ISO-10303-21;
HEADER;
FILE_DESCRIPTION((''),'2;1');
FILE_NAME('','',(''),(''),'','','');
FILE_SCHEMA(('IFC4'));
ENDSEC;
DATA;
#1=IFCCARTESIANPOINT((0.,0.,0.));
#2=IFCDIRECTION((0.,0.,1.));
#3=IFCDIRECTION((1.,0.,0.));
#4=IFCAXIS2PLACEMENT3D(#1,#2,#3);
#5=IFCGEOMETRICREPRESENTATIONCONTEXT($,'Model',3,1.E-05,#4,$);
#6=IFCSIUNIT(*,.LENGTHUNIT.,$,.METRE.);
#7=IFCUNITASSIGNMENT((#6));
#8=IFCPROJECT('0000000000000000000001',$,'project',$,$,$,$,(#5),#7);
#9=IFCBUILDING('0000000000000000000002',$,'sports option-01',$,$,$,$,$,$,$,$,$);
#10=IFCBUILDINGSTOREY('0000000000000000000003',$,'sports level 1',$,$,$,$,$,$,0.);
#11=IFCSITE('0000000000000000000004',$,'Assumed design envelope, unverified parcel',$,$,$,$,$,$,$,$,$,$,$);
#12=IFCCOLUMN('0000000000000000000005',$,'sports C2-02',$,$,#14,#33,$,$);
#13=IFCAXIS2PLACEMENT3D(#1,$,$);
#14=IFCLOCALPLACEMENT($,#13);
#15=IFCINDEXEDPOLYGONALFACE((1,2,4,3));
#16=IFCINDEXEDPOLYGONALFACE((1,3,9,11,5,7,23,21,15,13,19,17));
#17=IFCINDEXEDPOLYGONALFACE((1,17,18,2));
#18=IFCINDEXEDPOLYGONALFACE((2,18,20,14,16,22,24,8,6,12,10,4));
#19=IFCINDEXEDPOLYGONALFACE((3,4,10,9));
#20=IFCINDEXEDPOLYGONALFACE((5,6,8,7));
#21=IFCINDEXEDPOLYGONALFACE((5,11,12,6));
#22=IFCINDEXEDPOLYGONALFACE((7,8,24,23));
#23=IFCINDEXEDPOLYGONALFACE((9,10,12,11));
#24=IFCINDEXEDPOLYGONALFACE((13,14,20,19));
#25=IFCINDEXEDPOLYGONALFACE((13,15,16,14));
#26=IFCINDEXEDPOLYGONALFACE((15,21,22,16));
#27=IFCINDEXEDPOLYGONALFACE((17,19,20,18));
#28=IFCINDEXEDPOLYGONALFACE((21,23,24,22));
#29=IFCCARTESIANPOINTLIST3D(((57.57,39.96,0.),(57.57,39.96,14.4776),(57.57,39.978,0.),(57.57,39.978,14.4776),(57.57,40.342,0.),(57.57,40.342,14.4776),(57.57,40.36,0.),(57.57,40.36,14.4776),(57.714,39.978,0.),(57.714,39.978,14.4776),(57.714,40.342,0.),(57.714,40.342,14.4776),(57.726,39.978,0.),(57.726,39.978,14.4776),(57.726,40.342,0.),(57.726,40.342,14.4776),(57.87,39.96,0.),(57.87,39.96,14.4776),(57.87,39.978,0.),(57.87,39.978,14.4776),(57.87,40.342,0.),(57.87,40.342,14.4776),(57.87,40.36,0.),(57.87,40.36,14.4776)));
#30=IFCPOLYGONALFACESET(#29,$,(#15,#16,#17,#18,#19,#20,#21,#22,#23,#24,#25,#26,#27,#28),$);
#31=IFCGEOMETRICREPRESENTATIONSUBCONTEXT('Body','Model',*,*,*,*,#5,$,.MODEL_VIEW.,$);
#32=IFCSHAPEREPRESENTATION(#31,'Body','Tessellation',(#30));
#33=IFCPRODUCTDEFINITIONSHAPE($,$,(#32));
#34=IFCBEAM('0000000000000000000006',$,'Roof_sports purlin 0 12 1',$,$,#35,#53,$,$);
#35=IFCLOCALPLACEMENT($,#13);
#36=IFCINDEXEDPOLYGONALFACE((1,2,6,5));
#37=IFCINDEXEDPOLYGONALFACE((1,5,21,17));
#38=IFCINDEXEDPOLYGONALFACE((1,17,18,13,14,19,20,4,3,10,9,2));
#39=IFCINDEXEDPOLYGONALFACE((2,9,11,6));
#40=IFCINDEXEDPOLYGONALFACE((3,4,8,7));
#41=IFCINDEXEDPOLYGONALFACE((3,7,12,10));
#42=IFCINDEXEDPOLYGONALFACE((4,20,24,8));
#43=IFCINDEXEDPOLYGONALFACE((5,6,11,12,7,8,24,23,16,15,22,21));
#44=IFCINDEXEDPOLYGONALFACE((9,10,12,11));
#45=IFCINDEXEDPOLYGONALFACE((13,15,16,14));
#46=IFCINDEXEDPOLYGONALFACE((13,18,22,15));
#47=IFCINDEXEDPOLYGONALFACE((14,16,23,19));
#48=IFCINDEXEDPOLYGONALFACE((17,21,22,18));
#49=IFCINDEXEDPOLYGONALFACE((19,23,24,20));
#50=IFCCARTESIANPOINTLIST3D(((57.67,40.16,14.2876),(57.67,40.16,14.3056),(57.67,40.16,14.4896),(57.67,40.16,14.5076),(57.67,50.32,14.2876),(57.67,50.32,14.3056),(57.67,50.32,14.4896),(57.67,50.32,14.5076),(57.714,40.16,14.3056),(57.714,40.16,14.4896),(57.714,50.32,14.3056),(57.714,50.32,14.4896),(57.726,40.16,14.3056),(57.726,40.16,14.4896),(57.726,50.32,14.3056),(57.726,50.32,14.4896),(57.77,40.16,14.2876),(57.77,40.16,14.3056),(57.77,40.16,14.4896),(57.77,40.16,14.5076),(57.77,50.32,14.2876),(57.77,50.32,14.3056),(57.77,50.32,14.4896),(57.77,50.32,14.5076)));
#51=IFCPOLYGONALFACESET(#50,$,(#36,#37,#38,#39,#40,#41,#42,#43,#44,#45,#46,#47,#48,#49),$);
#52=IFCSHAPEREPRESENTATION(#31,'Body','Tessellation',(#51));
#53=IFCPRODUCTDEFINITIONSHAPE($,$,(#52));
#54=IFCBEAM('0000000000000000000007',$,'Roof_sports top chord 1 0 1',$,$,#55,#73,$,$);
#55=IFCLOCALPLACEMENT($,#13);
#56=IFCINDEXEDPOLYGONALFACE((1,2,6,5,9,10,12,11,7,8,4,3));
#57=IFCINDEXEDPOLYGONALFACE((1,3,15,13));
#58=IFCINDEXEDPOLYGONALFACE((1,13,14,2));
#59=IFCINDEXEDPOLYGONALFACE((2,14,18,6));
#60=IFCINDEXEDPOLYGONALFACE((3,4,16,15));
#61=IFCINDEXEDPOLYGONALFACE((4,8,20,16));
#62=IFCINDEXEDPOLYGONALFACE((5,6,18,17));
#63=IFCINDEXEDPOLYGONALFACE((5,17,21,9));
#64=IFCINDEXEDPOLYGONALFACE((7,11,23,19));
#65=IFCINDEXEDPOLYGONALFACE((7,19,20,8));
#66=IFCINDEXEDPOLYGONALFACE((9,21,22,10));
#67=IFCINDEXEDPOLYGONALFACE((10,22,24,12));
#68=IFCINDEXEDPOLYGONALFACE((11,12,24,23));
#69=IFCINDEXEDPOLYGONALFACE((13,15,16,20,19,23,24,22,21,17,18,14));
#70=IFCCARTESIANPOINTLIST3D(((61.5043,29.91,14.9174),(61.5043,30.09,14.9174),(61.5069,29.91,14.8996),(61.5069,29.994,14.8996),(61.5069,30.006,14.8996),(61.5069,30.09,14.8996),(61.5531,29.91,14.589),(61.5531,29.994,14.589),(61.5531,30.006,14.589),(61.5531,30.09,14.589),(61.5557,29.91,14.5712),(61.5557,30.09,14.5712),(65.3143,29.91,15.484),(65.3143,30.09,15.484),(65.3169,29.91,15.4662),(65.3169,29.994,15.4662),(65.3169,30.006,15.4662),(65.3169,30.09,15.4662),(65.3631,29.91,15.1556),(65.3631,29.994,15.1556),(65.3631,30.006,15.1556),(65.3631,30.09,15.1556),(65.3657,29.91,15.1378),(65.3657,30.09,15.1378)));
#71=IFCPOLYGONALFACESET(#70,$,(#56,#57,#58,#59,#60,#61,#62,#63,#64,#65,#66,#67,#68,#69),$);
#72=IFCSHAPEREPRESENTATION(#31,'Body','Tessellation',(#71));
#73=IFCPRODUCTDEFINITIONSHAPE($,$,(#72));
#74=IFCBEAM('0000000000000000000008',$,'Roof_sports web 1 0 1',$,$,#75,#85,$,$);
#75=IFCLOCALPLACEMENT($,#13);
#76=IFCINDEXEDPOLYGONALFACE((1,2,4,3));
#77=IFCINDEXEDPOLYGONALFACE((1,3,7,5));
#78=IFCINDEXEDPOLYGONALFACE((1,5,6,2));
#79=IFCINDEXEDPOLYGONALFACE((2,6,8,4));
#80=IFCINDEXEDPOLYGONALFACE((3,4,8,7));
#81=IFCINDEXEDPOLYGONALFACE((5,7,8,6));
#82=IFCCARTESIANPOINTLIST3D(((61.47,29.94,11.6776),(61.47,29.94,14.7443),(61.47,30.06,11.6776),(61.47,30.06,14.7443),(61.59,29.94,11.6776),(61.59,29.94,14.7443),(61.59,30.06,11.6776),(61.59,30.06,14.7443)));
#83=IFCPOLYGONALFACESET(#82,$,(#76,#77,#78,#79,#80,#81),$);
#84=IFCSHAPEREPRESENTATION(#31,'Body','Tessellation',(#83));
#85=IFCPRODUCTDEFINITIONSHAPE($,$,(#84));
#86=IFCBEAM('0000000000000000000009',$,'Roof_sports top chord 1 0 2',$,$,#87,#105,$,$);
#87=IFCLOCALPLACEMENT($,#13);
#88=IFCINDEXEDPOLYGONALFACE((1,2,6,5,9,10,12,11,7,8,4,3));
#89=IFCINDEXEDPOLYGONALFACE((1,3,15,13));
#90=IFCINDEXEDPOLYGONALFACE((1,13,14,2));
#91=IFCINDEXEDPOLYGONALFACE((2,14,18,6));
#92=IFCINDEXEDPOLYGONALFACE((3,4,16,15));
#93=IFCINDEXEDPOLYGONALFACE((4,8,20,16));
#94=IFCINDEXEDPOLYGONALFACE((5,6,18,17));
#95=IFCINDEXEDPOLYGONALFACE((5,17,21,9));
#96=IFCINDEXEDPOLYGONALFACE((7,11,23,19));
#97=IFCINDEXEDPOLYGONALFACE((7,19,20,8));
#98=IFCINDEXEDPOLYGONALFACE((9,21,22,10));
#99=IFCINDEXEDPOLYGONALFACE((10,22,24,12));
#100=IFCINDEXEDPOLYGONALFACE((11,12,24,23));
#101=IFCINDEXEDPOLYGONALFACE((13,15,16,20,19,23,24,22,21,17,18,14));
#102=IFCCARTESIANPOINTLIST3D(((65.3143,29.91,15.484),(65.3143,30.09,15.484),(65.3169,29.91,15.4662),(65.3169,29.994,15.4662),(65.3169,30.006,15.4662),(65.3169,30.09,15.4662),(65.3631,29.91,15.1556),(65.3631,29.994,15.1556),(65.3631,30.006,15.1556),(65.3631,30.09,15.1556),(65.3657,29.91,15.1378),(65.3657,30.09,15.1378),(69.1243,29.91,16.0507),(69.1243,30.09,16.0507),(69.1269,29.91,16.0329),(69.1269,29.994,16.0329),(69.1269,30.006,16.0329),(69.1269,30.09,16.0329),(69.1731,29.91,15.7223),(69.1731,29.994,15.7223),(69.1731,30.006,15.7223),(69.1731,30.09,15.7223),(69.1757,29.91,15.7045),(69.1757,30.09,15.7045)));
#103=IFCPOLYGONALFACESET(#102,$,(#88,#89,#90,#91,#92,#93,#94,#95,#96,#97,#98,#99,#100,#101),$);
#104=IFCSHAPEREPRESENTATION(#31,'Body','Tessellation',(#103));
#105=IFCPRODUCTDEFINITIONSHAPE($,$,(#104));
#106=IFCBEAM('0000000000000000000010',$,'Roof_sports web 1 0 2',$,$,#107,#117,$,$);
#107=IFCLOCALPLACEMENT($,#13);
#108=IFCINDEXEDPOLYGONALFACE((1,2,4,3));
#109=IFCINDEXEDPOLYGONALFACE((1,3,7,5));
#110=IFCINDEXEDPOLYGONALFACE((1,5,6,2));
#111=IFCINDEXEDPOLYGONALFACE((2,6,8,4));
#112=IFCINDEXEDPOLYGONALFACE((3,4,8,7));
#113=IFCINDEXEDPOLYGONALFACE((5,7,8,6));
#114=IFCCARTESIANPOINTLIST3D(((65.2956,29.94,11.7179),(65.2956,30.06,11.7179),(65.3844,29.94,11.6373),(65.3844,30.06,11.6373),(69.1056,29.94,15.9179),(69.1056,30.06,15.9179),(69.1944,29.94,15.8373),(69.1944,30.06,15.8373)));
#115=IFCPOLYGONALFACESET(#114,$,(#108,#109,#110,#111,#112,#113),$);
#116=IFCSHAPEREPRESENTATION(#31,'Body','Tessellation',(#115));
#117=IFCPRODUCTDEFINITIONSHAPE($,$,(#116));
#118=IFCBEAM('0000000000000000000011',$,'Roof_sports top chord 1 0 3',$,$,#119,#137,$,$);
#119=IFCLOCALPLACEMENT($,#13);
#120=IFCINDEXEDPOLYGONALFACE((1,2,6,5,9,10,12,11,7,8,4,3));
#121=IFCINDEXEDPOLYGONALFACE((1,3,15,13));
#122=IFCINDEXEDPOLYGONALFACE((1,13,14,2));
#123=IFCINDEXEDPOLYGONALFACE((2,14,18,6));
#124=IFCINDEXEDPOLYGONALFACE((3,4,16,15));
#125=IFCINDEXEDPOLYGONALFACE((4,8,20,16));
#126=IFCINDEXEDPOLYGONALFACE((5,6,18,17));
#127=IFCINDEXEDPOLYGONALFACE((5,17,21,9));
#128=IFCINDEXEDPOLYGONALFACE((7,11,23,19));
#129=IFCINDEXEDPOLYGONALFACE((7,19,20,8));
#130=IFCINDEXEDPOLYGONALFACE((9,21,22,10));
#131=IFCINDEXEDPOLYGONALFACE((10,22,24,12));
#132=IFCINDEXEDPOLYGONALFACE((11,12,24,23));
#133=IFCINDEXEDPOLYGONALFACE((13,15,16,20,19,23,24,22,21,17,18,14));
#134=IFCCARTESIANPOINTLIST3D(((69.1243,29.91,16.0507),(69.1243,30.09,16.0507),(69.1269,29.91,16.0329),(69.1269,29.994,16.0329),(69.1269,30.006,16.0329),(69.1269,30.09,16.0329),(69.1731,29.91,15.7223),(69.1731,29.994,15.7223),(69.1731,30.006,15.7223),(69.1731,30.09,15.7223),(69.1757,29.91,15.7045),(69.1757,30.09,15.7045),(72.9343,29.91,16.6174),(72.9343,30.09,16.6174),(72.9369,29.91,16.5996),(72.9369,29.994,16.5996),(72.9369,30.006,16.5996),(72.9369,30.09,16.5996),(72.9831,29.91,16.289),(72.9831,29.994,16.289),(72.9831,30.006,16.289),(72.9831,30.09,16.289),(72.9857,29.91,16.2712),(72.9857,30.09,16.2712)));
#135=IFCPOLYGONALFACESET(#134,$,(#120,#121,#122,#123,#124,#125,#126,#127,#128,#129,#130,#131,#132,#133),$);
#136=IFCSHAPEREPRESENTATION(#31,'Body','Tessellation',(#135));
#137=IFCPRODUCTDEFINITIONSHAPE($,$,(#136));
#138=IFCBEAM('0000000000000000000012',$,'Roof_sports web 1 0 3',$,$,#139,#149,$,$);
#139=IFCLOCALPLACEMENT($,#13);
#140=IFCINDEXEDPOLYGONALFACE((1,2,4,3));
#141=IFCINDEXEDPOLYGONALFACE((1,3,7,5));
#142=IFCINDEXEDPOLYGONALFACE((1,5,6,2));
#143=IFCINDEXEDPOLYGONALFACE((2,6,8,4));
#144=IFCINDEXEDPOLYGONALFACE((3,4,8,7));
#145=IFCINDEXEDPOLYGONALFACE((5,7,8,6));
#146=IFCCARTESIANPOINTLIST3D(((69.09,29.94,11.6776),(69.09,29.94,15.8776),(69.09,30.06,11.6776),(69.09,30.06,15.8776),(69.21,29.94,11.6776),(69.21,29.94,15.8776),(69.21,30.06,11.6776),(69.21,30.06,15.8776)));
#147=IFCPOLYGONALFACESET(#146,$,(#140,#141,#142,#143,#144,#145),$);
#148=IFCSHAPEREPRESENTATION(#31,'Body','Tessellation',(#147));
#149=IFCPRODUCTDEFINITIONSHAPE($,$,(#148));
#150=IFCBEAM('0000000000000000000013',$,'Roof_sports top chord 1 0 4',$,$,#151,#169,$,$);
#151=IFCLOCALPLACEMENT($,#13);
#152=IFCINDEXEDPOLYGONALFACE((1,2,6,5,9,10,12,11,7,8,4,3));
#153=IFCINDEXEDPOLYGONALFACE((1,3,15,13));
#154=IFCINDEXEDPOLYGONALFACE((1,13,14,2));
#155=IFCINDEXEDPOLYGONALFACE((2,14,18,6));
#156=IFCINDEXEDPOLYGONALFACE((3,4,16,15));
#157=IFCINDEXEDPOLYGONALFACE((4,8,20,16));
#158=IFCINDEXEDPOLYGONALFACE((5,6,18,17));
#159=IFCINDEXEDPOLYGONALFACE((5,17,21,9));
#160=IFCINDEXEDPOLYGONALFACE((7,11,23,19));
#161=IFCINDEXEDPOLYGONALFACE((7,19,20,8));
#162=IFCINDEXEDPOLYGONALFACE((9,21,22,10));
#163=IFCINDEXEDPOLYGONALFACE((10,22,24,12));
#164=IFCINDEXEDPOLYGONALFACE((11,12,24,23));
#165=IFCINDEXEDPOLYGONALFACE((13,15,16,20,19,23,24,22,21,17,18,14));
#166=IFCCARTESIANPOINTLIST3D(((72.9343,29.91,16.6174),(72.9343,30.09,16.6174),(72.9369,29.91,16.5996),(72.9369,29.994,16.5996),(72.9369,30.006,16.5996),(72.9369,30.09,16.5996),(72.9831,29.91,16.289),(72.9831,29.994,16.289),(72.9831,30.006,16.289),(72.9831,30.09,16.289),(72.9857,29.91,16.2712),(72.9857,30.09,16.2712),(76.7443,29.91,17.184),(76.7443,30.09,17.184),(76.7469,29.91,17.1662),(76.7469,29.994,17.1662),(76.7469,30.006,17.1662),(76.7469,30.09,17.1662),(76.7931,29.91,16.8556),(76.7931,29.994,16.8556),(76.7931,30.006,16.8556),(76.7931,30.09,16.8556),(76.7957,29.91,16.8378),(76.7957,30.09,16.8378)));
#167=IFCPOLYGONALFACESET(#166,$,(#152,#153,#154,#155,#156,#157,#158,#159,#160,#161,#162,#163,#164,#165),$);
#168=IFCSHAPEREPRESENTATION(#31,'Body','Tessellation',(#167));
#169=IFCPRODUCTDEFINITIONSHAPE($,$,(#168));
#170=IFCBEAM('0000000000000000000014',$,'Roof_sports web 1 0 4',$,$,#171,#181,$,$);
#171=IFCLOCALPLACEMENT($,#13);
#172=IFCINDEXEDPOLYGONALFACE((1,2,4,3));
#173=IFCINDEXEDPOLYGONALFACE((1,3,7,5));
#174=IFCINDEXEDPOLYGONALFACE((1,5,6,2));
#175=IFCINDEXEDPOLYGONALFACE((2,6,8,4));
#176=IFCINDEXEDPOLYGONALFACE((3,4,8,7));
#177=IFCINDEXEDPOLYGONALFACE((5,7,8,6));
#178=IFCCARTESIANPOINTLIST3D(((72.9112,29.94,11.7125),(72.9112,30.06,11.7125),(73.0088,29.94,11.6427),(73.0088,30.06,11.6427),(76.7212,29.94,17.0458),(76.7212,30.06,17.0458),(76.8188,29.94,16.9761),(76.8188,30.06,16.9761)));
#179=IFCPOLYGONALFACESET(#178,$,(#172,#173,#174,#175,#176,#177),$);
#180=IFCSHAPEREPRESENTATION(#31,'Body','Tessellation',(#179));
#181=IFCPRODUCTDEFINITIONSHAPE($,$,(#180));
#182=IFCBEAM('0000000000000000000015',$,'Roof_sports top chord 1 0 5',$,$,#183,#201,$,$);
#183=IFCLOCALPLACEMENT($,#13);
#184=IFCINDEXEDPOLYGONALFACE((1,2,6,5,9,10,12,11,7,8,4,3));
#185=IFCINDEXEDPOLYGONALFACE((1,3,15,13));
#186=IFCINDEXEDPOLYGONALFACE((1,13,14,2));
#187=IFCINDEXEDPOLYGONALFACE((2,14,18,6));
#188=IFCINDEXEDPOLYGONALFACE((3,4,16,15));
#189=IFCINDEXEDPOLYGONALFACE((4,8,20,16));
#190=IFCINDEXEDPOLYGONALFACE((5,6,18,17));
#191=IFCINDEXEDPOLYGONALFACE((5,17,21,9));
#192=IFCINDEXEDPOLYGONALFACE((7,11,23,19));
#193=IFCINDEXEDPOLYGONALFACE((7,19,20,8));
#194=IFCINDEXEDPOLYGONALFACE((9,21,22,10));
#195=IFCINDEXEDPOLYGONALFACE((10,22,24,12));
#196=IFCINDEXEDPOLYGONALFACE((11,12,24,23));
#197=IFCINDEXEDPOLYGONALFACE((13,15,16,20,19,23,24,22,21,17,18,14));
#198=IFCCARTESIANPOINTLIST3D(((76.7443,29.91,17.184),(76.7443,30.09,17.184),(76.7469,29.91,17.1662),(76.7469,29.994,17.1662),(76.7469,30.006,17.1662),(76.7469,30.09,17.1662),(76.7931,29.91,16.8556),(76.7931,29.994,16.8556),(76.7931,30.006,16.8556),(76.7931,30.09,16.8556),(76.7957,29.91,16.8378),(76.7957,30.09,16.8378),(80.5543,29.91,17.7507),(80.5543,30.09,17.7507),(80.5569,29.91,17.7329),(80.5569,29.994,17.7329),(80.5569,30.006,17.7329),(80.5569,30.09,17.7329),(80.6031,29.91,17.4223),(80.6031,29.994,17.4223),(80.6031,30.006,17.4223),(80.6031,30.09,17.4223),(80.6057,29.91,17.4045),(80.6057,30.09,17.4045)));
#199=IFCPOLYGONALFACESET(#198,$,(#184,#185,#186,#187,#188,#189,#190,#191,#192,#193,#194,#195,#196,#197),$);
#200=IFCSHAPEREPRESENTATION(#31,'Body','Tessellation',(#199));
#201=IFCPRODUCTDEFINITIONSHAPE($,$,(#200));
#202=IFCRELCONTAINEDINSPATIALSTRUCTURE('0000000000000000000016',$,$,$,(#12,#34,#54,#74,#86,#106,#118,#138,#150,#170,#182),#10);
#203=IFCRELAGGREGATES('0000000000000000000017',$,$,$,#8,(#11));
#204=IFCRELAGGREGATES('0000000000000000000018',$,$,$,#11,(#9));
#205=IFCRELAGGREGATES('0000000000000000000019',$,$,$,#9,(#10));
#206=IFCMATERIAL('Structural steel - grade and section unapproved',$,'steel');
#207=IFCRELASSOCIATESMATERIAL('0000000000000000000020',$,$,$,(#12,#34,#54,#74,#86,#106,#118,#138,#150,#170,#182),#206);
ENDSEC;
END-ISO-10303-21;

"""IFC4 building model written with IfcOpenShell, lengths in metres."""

from ifc_helpers import new_model, si_unit, frame, origin_with_axes, place, context, subcontext, project, spatial, rectangle, i_section, extrude, material, element, save


model = new_model("IFC4")

# Units and contexts
model_context = context("Model", 3, precision=1e-05, world=origin_with_axes())
body_context = subcontext(model_context, "Body", "Model", "MODEL_VIEW")
ifc_project = project(units=[si_unit("LENGTHUNIT", "METRE")], contexts=[model_context])

# Site, building, storey
site = spatial("IfcSite", under=ifc_project, Name="Assumed design envelope, unverified parcel")
building = spatial("IfcBuilding", under=site, Name="sports option-01")
storey = spatial("IfcBuildingStorey", under=building, Name="sports level 1", Elevation=0.0)

# Column
ifc_material = material(Name="Structural steel - grade and section unapproved", Category="steel")
column_placement = place(None, frame((57.72, 40.16, 0.0), z_axis=(0.0, 0.0, 1.0), x_axis=(-1.0, 0.0, 0.0)))
element("IfcColumn", 1, at=column_placement, inside=storey, material=ifc_material, Name="sports C2-02", context=body_context, shape_type="SweptSolid", body=[
    extrude(i_section(OverallWidth=0.3, OverallDepth=0.4, WebThickness=0.012, FlangeThickness=0.018, FilletRadius=0.0), origin_with_axes(), (0.0, 0.0, 1.0), 14.4776),
])

# Beams
beam_1_placement = place(None, frame((57.72, 40.16, 14.3976), z_axis=(0.0, 1.0, 0.0), x_axis=(-1.0, 0.0, 0.0)))
element("IfcBeam", 2, at=beam_1_placement, inside=storey, material=ifc_material, Name="Roof_sports purlin 0 12 1", context=body_context, shape_type="SweptSolid", body=[
    extrude(i_section(OverallWidth=0.1, OverallDepth=0.22, WebThickness=0.012, FlangeThickness=0.018, FilletRadius=0.0), origin_with_axes(), (0.0, 0.0, 1.0), 10.16),
])
beam_2_placement = place(None, frame((61.53, 30.0, 14.7443), z_axis=(0.98912, 0.0, 0.147113), x_axis=(0.0, 1.0, 0.0)))
element("IfcBeam", 3, at=beam_2_placement, inside=storey, material=ifc_material, Name="Roof_sports top chord 1 0 1", context=body_context, shape_type="SweptSolid", body=[
    extrude(i_section(OverallWidth=0.18, OverallDepth=0.35, WebThickness=0.012, FlangeThickness=0.018, FilletRadius=0.0), origin_with_axes(), (0.0, 0.0, 1.0), 3.8519),
])
beam_3_placement = place(None, frame((61.53, 30.0, 11.6776), z_axis=(0.0, 0.0, 1.0), x_axis=(-1.0, 0.0, 0.0)))
element("IfcBeam", 4, at=beam_3_placement, inside=storey, material=ifc_material, Name="Roof_sports web 1 0 1", context=body_context, shape_type="SweptSolid", body=[
    extrude(rectangle(XDim=0.12, YDim=0.12), origin_with_axes(), (0.0, 0.0, 1.0), 3.0667),
])
beam_4_placement = place(None, frame((65.34, 30.0, 15.3109), z_axis=(0.98912, 0.0, 0.147113), x_axis=(0.0, 1.0, 0.0)))
element("IfcBeam", 5, at=beam_4_placement, inside=storey, material=ifc_material, Name="Roof_sports top chord 1 0 2", context=body_context, shape_type="SweptSolid", body=[
    extrude(i_section(OverallWidth=0.18, OverallDepth=0.35, WebThickness=0.012, FlangeThickness=0.018, FilletRadius=0.0), origin_with_axes(), (0.0, 0.0, 1.0), 3.8519),
])
beam_5_placement = place(None, frame((65.34, 30.0, 11.6776), z_axis=(0.671883, 0.0, 0.740657), x_axis=(0.0, 1.0, 0.0)))
element("IfcBeam", 6, at=beam_5_placement, inside=storey, material=ifc_material, Name="Roof_sports web 1 0 2", context=body_context, shape_type="SweptSolid", body=[
    extrude(rectangle(XDim=0.12, YDim=0.12), origin_with_axes(), (0.0, 0.0, 1.0), 5.6706),
])
beam_6_placement = place(None, frame((69.15, 30.0, 15.8776), z_axis=(0.98912, 0.0, 0.147113), x_axis=(0.0, 1.0, 0.0)))
element("IfcBeam", 7, at=beam_6_placement, inside=storey, material=ifc_material, Name="Roof_sports top chord 1 0 3", context=body_context, shape_type="SweptSolid", body=[
    extrude(i_section(OverallWidth=0.18, OverallDepth=0.35, WebThickness=0.012, FlangeThickness=0.018, FilletRadius=0.0), origin_with_axes(), (0.0, 0.0, 1.0), 3.8519),
])
beam_7_placement = place(None, frame((69.15, 30.0, 11.6776), z_axis=(0.0, 0.0, 1.0), x_axis=(-1.0, 0.0, 0.0)))
element("IfcBeam", 8, at=beam_7_placement, inside=storey, material=ifc_material, Name="Roof_sports web 1 0 3", context=body_context, shape_type="SweptSolid", body=[
    extrude(rectangle(XDim=0.12, YDim=0.12), origin_with_axes(), (0.0, 0.0, 1.0), 4.2),
])
beam_8_placement = place(None, frame((72.96, 30.0, 16.4443), z_axis=(0.98912, 0.0, 0.147113), x_axis=(0.0, 1.0, 0.0)))
element("IfcBeam", 9, at=beam_8_placement, inside=storey, material=ifc_material, Name="Roof_sports top chord 1 0 4", context=body_context, shape_type="SweptSolid", body=[
    extrude(i_section(OverallWidth=0.18, OverallDepth=0.35, WebThickness=0.012, FlangeThickness=0.018, FilletRadius=0.0), origin_with_axes(), (0.0, 0.0, 1.0), 3.8519),
])
beam_9_placement = place(None, frame((72.96, 30.0, 11.6776), z_axis=(0.581286, 0.0, 0.813699), x_axis=(0.0, 1.0, 0.0)))
element("IfcBeam", 10, at=beam_9_placement, inside=storey, material=ifc_material, Name="Roof_sports web 1 0 4", context=body_context, shape_type="SweptSolid", body=[
    extrude(rectangle(XDim=0.12, YDim=0.12), origin_with_axes(), (0.0, 0.0, 1.0), 6.5544),
])
beam_10_placement = place(None, frame((76.77, 30.0, 17.0109), z_axis=(0.98912, 0.0, 0.147113), x_axis=(0.0, 1.0, 0.0)))
element("IfcBeam", 11, at=beam_10_placement, inside=storey, material=ifc_material, Name="Roof_sports top chord 1 0 5", context=body_context, shape_type="SweptSolid", body=[
    extrude(i_section(OverallWidth=0.18, OverallDepth=0.35, WebThickness=0.012, FlangeThickness=0.018, FilletRadius=0.0), origin_with_axes(), (0.0, 0.0, 1.0), 3.8519),
])

save(model, "model.ifc")
